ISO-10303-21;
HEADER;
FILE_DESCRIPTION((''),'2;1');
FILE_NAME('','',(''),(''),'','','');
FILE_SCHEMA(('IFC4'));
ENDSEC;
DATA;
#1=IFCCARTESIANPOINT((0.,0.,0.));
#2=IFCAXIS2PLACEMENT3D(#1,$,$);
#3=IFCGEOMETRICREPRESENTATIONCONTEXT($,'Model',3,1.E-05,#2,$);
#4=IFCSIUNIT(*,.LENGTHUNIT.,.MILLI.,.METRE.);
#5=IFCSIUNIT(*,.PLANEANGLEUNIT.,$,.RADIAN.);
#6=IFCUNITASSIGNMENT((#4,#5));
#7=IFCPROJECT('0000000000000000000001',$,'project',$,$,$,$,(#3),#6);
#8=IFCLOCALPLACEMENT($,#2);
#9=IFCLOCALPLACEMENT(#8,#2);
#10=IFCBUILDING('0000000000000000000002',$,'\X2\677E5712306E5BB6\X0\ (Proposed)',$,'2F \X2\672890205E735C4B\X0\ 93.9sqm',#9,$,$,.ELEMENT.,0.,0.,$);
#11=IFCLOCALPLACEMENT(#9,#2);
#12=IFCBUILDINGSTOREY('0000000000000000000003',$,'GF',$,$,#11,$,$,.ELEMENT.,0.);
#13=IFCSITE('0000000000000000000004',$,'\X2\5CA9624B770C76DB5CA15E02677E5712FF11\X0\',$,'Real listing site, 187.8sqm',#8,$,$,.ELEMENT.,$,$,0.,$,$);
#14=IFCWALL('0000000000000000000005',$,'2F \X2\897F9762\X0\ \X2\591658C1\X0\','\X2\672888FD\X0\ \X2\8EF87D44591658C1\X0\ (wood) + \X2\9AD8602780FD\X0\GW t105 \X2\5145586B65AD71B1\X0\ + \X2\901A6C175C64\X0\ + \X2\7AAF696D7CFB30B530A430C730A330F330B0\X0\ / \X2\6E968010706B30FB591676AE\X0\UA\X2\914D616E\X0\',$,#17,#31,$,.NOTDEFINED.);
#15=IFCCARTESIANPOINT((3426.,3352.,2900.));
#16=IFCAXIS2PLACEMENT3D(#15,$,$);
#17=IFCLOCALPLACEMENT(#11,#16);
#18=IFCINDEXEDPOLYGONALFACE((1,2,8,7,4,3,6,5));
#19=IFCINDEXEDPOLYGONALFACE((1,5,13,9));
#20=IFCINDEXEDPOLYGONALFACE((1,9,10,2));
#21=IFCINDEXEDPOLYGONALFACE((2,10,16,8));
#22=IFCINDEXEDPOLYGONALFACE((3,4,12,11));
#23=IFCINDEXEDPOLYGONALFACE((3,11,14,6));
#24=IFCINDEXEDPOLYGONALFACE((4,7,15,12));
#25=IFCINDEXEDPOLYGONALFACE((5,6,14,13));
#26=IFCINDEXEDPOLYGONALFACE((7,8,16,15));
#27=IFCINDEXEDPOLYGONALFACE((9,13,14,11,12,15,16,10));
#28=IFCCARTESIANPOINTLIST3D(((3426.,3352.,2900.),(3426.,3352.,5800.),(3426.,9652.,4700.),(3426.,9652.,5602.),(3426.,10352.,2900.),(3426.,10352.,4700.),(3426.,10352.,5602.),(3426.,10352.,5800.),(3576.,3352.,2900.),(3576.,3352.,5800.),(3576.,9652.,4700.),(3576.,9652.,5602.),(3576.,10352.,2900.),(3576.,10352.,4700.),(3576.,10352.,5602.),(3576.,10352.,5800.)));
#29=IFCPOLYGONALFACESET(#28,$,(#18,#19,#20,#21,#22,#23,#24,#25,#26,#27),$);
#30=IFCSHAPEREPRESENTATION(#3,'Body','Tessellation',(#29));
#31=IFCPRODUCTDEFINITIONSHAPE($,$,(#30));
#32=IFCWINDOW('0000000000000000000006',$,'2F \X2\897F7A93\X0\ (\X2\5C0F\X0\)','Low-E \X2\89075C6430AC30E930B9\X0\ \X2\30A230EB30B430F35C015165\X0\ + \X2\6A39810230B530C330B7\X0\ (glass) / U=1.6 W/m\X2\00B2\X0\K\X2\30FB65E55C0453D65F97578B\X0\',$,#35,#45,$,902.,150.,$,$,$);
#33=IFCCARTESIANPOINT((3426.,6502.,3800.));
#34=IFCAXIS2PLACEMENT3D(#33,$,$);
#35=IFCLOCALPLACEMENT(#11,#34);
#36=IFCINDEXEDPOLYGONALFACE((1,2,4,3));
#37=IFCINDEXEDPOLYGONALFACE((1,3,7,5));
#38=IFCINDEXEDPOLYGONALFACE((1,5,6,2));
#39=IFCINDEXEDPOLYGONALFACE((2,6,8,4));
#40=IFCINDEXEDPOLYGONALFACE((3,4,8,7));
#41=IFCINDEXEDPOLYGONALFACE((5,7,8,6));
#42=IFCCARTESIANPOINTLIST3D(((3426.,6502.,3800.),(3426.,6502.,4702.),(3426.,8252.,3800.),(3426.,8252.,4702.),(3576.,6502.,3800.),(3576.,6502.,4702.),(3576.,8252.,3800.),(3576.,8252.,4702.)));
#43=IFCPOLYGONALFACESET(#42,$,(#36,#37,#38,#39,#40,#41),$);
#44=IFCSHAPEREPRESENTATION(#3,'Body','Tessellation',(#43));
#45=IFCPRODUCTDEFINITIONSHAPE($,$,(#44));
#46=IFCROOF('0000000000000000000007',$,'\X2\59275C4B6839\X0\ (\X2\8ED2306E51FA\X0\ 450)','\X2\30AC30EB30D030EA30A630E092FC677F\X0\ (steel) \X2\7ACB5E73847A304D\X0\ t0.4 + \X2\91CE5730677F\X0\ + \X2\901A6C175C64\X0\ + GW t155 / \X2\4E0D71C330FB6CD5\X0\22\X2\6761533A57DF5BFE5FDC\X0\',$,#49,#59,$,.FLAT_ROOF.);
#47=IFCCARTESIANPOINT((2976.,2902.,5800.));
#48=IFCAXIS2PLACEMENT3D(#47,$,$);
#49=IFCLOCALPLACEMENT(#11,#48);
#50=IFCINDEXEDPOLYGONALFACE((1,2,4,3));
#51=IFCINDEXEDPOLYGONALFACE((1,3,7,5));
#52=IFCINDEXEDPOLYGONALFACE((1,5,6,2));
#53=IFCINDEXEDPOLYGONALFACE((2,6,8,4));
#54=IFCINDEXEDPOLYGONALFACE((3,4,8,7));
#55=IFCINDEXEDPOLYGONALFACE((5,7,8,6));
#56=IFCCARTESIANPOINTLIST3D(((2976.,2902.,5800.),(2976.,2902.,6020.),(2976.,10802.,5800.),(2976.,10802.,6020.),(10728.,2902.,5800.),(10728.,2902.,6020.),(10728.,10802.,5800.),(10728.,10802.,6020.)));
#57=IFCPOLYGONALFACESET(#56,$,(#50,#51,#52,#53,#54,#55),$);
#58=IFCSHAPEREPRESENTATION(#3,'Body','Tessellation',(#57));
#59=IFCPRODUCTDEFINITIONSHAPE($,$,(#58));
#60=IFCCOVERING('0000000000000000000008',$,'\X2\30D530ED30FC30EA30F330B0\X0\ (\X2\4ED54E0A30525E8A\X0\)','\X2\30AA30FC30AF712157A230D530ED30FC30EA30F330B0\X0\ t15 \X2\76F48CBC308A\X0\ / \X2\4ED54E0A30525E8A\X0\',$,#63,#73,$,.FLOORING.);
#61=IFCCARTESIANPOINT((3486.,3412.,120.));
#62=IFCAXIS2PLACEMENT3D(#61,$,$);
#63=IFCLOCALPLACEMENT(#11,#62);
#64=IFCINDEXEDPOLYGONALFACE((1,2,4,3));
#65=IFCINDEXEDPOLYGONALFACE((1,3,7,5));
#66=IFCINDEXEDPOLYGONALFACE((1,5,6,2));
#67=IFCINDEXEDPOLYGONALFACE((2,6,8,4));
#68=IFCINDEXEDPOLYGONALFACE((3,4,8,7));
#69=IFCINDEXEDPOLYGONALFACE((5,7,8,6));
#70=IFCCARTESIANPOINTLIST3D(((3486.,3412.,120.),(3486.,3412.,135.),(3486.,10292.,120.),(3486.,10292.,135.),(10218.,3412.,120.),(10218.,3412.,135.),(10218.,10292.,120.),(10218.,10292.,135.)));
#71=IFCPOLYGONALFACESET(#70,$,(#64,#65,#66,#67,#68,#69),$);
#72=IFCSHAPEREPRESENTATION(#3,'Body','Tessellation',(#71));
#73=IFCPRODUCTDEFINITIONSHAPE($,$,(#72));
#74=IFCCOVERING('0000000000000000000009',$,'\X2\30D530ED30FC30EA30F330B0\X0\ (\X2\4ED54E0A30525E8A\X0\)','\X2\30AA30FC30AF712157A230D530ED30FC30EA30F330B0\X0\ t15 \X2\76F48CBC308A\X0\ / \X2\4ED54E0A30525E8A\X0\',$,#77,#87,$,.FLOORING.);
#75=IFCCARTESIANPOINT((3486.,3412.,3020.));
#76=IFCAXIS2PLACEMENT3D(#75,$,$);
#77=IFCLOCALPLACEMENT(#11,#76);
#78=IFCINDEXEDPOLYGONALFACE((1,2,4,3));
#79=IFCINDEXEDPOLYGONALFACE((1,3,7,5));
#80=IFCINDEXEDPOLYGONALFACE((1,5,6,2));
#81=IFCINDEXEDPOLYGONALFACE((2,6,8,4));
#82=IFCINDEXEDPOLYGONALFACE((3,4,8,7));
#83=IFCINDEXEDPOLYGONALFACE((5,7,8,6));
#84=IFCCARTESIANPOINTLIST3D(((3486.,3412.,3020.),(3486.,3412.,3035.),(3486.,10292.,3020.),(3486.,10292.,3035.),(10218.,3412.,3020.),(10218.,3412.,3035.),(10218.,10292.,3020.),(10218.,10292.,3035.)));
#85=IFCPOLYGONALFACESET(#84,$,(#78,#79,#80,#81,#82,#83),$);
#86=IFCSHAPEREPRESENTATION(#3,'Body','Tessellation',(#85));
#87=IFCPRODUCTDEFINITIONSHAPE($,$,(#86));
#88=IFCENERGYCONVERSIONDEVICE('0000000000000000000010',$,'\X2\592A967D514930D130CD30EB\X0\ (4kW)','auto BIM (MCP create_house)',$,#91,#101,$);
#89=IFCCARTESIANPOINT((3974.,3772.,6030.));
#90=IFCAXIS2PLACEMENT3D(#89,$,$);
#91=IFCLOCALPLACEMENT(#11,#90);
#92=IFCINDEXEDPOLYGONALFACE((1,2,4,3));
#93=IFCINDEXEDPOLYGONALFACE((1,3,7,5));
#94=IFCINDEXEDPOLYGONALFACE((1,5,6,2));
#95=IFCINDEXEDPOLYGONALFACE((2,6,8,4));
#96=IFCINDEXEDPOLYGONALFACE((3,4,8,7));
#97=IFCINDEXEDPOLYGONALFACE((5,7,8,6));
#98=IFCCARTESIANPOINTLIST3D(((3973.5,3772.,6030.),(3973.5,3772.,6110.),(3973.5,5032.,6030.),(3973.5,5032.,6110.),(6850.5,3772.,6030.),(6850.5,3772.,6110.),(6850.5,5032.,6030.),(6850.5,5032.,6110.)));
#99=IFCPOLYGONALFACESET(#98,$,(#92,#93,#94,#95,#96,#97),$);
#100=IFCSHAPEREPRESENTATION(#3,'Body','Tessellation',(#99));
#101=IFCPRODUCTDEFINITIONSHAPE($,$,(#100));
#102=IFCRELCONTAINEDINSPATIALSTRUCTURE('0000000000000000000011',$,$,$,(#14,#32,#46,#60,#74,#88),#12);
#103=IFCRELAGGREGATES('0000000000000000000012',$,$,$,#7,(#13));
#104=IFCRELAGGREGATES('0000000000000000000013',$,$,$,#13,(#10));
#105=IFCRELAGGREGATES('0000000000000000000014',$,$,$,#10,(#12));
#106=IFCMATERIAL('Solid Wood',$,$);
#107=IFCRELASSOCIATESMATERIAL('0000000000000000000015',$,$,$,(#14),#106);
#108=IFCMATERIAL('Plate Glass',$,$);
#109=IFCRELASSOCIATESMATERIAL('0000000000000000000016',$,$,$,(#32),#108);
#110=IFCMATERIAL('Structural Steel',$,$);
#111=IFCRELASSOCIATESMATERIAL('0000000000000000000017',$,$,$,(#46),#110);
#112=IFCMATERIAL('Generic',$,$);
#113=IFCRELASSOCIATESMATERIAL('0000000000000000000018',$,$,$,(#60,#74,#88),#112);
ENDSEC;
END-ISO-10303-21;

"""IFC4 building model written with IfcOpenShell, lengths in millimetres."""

from ifc_helpers import new_model, si_unit, frame, frame_2d, origin, place, context, project, spatial, rectangle, extrude, material, element, fill, save


model = new_model("IFC4")

# Units and contexts
model_context = context("Model", 3, precision=1e-05, world=origin())
ifc_project = project(units=[si_unit("LENGTHUNIT", "METRE", prefix="MILLI"), si_unit("PLANEANGLEUNIT", "RADIAN")], contexts=[model_context])

# Site, building, storey
site_placement = place(None, origin())
site = spatial("IfcSite", under=ifc_project, at=site_placement, Name="岩手県盛岡市松園１", ObjectType="Real listing site, 187.8sqm", CompositionType="ELEMENT", RefElevation=0.0)
building_placement = place(site_placement, origin())
building = spatial("IfcBuilding", under=site, at=building_placement, Name="松園の家 (Proposed)", ObjectType="2F 木造平屋 93.9sqm", CompositionType="ELEMENT", ElevationOfRefHeight=0.0, ElevationOfTerrain=0.0)
storey_placement = place(building_placement, origin())
storey = spatial("IfcBuildingStorey", under=building, at=storey_placement, Name="GF", CompositionType="ELEMENT", Elevation=0.0)

# Shared definitions
ifc_material_1 = material(Name="Solid Wood")

# Shared definitions
ifc_material_2 = material(Name="Plate Glass")

# Wall, opening, window
wall_1_placement = place(storey_placement, frame((3426.0, 3352.0, 2900.0)))
wall_1 = element("IfcWall", 1, at=wall_1_placement, inside=storey, material=ifc_material_1, Name="2F 西面 外壁", Description="木製 軸組外壁 (wood) + 高性能GW t105 充填断熱 + 通気層 + 窯業系サイディング / 準耐火・外皮UA配慮", PredefinedType="NOTDEFINED", context=model_context, shape_type="SweptSolid", body=[
    extrude(rectangle(XDim=150.0, YDim=7000.0, at=frame_2d((75.0, 3500.0))), frame((3426.0, 3352.0, 2900.0)), (0.0, 0.0, 1.0), 2900.0),
])
opening_1_placement = place(storey_placement, frame((3426.0, 6502.0, 3800.0)))
opening_1 = element("IfcOpeningElement", 2, at=opening_1_placement, cuts=wall_1, PredefinedType="NOTDEFINED", context=model_context, shape_type="SweptSolid", body=[
    extrude(rectangle(XDim=150.0, YDim=1750.0, at=frame_2d((75.0, 875.0))), frame((3426.0, 6502.0, 3800.0)), (0.0, 0.0, 1.0), 902.0),
])
window_1_placement = place(storey_placement, frame((3426.0, 6502.0, 3800.0)))
window_1 = element("IfcWindow", 3, at=window_1_placement, inside=storey, material=ifc_material_2, Name="2F 西窓 (小)", Description="Low-E 複層ガラス アルゴン封入 + 樹脂サッシ (glass) / U=1.6 W/m²K・日射取得型", OverallHeight=902.0, OverallWidth=150.0, context=model_context, shape_type="SweptSolid", body=[
    extrude(rectangle(XDim=150.0, YDim=1750.0, at=frame_2d((75.0, 875.0))), frame((3426.0, 6502.0, 3800.0)), (0.0, 0.0, 1.0), 902.0),
])
fill(opening_1, window_1)

# Roof
ifc_material_3 = material(Name="Structural Steel")
roof_placement = place(storey_placement, frame((2976.0, 2902.0, 5800.0)))
element("IfcRoof", 4, at=roof_placement, inside=storey, material=ifc_material_3, Name="大屋根 (軒の出 450)", Description="ガルバリウム鋼板 (steel) 立平葺き t0.4 + 野地板 + 通気層 + GW t155 / 不燃・法22条区域対応", PredefinedType="FLAT_ROOF", context=model_context, shape_type="SweptSolid", body=[
    extrude(rectangle(XDim=7752.0, YDim=7900.0, at=frame_2d((3876.0, 3950.0))), frame((2976.0, 2902.0, 5800.0)), (0.0, 0.0, 1.0), 220.0),
])

# Coverings
ifc_material_4 = material(Name="Generic")
covering_1_placement = place(storey_placement, frame((3486.0, 3412.0, 120.0)))
element("IfcCovering", 5, at=covering_1_placement, inside=storey, material=ifc_material_4, Name="フローリング (仕上げ床)", Description="オーク無垢フローリング t15 直貼り / 仕上げ床", PredefinedType="FLOORING", context=model_context, shape_type="SweptSolid", body=[
    extrude(rectangle(XDim=6732.0, YDim=6880.0, at=frame_2d((3366.0, 3440.0))), frame((3486.0, 3412.0, 120.0)), (0.0, 0.0, 1.0), 15.0),
])
covering_2_placement = place(storey_placement, frame((3486.0, 3412.0, 3020.0)))
element("IfcCovering", 6, at=covering_2_placement, inside=storey, material=ifc_material_4, Name="フローリング (仕上げ床)", Description="オーク無垢フローリング t15 直貼り / 仕上げ床", PredefinedType="FLOORING", context=model_context, shape_type="SweptSolid", body=[
    extrude(rectangle(XDim=6732.0, YDim=6880.0, at=frame_2d((3366.0, 3440.0))), frame((3486.0, 3412.0, 3020.0)), (0.0, 0.0, 1.0), 15.0),
])

# Energy conversion device
energy_conversion_device_placement = place(storey_placement, frame((3974.0, 3772.0, 6030.0)))
element("IfcEnergyConversionDevice", 7, at=energy_conversion_device_placement, inside=storey, material=ifc_material_4, Name="太陽光パネル (4kW)", Description="auto BIM (MCP create_house)", context=model_context, shape_type="SweptSolid", body=[
    extrude(rectangle(XDim=2877.0, YDim=1260.0, at=frame_2d((1438.0, 630.0))), frame((3974.0, 3772.0, 6030.0)), (0.0, 0.0, 1.0), 80.0),
])

save(model, "model.ifc")
